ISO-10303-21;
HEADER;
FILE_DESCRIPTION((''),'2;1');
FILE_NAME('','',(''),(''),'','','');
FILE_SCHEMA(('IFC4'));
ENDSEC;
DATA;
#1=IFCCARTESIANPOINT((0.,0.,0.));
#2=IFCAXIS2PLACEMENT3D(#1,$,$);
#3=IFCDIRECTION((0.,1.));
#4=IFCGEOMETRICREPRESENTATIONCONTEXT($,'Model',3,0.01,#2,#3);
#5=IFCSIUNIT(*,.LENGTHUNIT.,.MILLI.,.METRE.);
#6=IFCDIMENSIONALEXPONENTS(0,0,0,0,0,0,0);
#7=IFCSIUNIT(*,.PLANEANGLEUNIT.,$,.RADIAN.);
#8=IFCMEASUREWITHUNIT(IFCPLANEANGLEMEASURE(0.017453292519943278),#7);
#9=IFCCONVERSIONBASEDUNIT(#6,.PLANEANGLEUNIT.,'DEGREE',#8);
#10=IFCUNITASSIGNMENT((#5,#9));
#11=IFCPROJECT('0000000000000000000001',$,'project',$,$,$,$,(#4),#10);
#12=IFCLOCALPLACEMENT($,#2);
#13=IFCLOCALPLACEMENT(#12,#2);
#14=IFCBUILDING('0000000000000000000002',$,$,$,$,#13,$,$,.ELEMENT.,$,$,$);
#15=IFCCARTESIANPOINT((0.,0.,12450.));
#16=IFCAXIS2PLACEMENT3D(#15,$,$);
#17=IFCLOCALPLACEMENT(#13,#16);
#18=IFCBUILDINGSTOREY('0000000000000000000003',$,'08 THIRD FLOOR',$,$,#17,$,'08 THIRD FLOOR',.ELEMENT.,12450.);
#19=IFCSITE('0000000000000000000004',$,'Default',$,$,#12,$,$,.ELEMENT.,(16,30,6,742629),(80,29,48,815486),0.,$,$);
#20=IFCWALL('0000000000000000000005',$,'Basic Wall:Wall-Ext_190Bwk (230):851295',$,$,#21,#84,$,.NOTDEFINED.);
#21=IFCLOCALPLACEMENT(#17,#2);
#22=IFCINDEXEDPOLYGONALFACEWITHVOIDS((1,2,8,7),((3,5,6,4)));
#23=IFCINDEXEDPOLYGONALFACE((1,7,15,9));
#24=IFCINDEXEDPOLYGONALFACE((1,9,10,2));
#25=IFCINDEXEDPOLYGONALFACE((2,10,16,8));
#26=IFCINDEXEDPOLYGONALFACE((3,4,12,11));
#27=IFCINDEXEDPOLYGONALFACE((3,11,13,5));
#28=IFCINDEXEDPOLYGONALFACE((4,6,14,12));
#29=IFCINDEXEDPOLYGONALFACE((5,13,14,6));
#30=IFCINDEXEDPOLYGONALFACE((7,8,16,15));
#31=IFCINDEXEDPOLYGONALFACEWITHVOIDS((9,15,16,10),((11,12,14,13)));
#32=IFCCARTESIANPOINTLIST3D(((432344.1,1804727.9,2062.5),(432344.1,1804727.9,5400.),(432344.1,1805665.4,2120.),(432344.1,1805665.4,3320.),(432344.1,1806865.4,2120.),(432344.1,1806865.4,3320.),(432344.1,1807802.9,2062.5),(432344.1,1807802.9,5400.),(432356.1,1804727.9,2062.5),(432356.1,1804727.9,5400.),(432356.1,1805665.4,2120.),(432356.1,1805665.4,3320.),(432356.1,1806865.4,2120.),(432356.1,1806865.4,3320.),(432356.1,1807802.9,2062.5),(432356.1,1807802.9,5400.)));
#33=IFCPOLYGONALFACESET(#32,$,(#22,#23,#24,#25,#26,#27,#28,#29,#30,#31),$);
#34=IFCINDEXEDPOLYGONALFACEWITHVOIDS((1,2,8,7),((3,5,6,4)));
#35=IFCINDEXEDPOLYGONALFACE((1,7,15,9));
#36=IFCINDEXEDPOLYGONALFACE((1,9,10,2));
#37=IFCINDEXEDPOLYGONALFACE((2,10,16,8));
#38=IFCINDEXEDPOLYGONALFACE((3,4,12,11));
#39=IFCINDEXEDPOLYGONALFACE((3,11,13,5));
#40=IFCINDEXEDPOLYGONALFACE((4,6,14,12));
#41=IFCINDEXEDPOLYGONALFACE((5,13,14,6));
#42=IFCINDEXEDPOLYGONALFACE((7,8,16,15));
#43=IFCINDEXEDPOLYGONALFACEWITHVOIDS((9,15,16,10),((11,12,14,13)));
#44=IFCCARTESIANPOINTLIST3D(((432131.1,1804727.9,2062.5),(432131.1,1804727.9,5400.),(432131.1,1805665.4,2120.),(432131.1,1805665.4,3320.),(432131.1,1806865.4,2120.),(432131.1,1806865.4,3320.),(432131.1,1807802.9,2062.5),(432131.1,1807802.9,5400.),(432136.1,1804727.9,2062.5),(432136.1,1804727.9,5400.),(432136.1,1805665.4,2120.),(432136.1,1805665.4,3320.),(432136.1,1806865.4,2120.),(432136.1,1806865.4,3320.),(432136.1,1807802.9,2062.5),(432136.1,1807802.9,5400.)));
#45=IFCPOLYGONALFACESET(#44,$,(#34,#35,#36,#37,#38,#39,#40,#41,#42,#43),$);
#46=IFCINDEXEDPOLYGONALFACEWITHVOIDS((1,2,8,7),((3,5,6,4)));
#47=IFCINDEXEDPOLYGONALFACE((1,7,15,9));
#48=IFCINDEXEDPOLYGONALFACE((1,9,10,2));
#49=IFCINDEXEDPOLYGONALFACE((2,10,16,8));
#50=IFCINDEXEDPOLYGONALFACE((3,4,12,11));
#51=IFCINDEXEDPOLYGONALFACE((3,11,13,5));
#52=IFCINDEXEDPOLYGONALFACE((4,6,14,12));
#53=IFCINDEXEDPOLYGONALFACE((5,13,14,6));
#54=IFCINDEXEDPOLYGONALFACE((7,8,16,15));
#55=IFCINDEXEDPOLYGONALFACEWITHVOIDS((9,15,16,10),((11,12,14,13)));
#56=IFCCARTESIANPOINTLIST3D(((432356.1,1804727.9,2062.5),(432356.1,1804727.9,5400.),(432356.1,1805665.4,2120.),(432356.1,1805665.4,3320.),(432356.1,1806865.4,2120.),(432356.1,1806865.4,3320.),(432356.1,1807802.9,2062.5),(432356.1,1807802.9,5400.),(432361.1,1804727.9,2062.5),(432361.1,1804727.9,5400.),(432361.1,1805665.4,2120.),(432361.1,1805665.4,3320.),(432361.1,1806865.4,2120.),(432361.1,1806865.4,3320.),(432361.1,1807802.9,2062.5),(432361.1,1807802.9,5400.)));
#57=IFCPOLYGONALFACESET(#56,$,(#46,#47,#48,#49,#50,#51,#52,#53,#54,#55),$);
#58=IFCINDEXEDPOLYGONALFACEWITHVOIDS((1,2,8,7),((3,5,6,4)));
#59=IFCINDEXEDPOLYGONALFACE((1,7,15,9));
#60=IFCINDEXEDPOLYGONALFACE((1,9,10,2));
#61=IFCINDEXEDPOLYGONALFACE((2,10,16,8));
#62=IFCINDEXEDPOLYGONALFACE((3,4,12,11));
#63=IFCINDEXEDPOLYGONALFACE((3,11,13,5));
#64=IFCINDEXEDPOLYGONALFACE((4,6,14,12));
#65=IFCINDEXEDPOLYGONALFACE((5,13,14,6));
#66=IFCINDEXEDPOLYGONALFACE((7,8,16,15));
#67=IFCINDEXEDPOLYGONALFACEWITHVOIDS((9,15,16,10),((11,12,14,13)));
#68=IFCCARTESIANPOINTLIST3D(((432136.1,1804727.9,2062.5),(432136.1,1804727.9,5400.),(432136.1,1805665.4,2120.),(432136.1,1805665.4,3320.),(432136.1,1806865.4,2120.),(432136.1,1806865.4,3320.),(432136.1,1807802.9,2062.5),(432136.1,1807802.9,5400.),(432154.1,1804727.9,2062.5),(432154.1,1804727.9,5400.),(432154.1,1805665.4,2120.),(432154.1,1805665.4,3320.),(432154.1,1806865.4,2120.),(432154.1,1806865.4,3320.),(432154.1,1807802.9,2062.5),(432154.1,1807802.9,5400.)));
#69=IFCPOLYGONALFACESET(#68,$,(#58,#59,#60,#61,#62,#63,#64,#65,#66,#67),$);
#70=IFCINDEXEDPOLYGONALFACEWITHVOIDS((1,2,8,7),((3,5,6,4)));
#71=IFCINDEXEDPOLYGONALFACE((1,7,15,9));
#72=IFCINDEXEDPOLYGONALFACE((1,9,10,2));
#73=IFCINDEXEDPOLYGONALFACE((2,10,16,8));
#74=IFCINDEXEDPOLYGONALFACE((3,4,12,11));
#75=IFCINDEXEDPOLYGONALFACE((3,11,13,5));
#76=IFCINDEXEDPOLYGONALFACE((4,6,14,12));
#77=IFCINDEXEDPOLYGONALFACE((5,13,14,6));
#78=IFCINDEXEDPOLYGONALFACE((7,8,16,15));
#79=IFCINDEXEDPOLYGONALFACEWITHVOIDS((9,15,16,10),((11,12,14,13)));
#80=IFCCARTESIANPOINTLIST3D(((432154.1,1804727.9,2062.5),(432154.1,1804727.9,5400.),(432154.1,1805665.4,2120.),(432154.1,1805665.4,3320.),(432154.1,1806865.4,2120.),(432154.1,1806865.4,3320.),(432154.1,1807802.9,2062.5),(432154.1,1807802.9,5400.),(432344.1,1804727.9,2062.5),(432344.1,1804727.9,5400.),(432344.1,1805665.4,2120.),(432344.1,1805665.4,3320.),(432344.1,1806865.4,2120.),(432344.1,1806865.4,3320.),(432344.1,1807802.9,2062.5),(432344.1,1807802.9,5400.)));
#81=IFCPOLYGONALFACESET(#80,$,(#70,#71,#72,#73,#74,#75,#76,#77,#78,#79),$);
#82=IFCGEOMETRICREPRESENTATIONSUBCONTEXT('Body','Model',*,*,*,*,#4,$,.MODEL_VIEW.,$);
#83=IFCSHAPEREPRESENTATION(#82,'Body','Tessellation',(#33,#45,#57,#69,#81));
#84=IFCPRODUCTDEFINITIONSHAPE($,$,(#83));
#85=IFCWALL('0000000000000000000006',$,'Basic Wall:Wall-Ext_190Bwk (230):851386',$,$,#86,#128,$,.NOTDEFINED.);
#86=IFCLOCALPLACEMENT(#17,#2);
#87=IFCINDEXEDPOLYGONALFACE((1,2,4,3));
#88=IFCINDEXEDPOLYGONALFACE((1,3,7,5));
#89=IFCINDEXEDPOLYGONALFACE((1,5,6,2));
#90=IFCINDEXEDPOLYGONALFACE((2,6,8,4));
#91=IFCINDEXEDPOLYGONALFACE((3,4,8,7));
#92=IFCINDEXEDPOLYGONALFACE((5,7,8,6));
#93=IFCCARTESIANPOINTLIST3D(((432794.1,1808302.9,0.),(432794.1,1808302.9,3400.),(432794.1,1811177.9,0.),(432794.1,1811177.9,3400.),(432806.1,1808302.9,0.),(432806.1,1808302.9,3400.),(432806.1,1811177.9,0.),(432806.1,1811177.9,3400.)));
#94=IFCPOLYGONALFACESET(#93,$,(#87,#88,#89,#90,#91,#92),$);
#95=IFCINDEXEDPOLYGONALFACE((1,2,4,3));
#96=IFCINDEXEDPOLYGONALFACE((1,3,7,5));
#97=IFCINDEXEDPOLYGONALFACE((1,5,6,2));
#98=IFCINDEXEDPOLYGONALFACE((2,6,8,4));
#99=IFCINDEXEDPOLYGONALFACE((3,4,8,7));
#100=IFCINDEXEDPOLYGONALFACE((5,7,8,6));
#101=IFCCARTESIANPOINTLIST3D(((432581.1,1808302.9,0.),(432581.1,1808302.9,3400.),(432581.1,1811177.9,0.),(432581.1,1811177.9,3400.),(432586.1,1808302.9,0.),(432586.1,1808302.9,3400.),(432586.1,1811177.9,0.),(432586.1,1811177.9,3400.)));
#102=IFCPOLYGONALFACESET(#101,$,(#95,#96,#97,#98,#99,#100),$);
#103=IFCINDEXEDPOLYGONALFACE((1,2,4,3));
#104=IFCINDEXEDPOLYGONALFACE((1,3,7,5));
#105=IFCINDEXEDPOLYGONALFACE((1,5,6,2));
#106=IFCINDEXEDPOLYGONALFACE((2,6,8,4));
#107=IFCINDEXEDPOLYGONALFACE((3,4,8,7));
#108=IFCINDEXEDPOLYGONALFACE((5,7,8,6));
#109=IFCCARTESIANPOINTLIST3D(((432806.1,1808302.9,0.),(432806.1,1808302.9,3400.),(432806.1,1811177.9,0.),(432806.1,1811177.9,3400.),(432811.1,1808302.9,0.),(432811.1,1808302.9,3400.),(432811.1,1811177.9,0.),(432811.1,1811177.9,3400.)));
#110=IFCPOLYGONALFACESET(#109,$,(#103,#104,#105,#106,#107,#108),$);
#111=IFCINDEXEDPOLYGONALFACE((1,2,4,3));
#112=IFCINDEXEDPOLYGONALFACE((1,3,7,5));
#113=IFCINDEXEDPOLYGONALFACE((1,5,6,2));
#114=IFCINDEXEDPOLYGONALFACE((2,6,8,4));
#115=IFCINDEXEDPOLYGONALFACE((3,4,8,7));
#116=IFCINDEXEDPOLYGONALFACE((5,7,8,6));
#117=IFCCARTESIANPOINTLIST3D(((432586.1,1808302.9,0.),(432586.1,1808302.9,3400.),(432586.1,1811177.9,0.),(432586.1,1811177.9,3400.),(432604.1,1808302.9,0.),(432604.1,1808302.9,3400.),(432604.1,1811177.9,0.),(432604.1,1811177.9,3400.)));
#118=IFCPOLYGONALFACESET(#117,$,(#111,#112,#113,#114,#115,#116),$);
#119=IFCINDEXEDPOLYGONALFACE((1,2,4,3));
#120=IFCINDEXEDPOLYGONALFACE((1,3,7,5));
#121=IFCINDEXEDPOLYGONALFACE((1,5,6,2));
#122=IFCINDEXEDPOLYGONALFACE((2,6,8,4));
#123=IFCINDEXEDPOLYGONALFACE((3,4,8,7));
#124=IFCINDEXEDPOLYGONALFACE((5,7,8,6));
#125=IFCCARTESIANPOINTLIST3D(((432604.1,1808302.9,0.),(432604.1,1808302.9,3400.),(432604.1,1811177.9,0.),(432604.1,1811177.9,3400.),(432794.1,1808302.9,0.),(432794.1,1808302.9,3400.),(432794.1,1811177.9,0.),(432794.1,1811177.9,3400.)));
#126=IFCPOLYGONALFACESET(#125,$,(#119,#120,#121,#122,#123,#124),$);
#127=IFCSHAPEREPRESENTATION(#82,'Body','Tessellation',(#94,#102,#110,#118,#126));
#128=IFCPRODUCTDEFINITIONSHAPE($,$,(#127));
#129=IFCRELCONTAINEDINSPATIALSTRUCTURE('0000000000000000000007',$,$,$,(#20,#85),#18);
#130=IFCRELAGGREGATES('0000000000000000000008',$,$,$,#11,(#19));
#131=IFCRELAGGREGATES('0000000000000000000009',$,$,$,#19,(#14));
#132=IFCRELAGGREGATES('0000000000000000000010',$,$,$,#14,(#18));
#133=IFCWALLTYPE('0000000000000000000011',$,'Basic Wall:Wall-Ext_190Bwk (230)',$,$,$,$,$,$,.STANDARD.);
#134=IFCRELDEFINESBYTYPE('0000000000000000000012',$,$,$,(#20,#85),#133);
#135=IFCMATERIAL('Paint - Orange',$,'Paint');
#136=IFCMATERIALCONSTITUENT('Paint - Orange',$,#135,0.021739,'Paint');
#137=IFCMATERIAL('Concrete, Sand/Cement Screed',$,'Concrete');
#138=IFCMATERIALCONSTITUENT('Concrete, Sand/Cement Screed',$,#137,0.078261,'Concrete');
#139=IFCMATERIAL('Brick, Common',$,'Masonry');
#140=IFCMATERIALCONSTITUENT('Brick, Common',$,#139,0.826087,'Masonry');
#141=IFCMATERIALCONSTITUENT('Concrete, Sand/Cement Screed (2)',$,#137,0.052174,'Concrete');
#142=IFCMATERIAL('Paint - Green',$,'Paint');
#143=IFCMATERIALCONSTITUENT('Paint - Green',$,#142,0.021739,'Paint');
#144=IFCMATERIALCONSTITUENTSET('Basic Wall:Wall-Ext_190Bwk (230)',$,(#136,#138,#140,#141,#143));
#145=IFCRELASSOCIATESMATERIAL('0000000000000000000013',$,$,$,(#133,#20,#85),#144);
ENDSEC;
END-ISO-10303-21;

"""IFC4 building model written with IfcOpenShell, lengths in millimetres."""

from ifc_helpers import new_model, entity, si_unit, converted_unit, direction, frame, origin, place, context, subcontext, project, spatial, indexed_curve, outline, extrude, material, constituent, constituent_set, type_object, element, save


model = new_model("IFC4")

# Units and contexts
model_context = context("Model", 3, precision=0.01, world=origin(), true_north=direction((0.0, 1.0)))
body_context = subcontext(model_context, "Body", "Model", "MODEL_VIEW")
ifc_project = project(units=[si_unit("LENGTHUNIT", "METRE", prefix="MILLI"), converted_unit("PLANEANGLEUNIT", "DEGREE", entity("IfcPlaneAngleMeasure", 0.017453292519943278), si_unit("PLANEANGLEUNIT", "RADIAN"), dimensions=[0, 0, 0, 0, 0, 0, 0])], contexts=[model_context])

# Site, building, storey
site_placement = place(None, origin())
site = spatial("IfcSite", under=ifc_project, at=site_placement, Name="Default", CompositionType="ELEMENT", RefLatitude=(16, 30, 6, 742629), RefLongitude=(80, 29, 48, 815486), RefElevation=0.0)
building_placement = place(site_placement, origin())
building = spatial("IfcBuilding", under=site, at=building_placement, CompositionType="ELEMENT")
storey_placement = place(building_placement, frame((0.0, 0.0, 12450.0)))
storey = spatial("IfcBuildingStorey", under=building, at=storey_placement, Name="08 THIRD FLOOR", LongName="08 THIRD FLOOR", CompositionType="ELEMENT", Elevation=12450.0)

# Shared definitions
ifc_material_1 = material(Name="Concrete, Sand/Cement Screed", Category="Concrete")
ifc_material_2 = material(Name="Brick, Common", Category="Masonry")

# Wall, opening
ifc_material_3 = material(Name="Paint - Orange", Category="Paint")
ifc_constituent_1 = constituent(ifc_material_3, Name="Paint - Orange", Category="Paint", fraction=0.021739)
ifc_constituent_2 = constituent(ifc_material_1, Name="Concrete, Sand/Cement Screed", Category="Concrete", fraction=0.078261)
ifc_constituent_3 = constituent(ifc_material_2, Name="Brick, Common", Category="Masonry", fraction=0.826087)
ifc_constituent_4 = constituent(ifc_material_1, Name="Concrete, Sand/Cement Screed (2)", Category="Concrete", fraction=0.052174)
ifc_material_4 = material(Name="Paint - Green", Category="Paint")
ifc_constituent_5 = constituent(ifc_material_4, Name="Paint - Green", Category="Paint", fraction=0.021739)
ifc_constituent_set_1 = constituent_set(constituents=[ifc_constituent_1, ifc_constituent_2, ifc_constituent_3, ifc_constituent_4, ifc_constituent_5], Name="Basic Wall:Wall-Ext_190Bwk (230)")
wall_type_1 = type_object("IfcWallType", Name="Basic Wall:Wall-Ext_190Bwk (230)", PredefinedType="STANDARD", material=ifc_constituent_set_1)
wall_1_placement = place(storey_placement, frame((432246.1, 1807802.9, 2062.5), z_axis=(0.0, 0.0, 1.0), x_axis=(0.0, -1.0, 0.0)))
wall_1 = element("IfcWall", 1, at=wall_1_placement, inside=storey, type_object=wall_type_1, material=ifc_constituent_set_1, Name="Basic Wall:Wall-Ext_190Bwk (230):851295", PredefinedType="NOTDEFINED", context=body_context, shape_type="SweptSolid", body=[
    extrude(outline(indexed_curve([(-1668.8, -1537.5), (1668.8, -1537.5), (1668.8, 1537.5), (-1668.8, 1537.5), (-1668.8, -1537.5)], self_intersect=False), holes=[indexed_curve([(-411.2, 600.0), (-411.2, -600.0), (-1611.2, -600.0), (-1611.2, 600.0), (-411.2, 600.0)], self_intersect=False)]), frame((1537.5, 98.0, 1668.8), z_axis=(0.0, 1.0, 0.0), x_axis=(0.0, 0.0, 1.0)), (0.0, 0.0, 1.0), 12.0),
    extrude(outline(indexed_curve([(-1668.8, -1537.5), (1668.8, -1537.5), (1668.8, 1537.5), (-1668.8, 1537.5), (-1668.8, -1537.5)], self_intersect=False), holes=[indexed_curve([(-411.2, 600.0), (-411.2, -600.0), (-1611.2, -600.0), (-1611.2, 600.0), (-411.2, 600.0)], self_intersect=False)]), frame((1537.5, -115.0, 1668.8), z_axis=(0.0, 1.0, 0.0), x_axis=(0.0, 0.0, 1.0)), (0.0, 0.0, 1.0), 5.0),
    extrude(outline(indexed_curve([(-1668.8, -1537.5), (1668.8, -1537.5), (1668.8, 1537.5), (-1668.8, 1537.5), (-1668.8, -1537.5)], self_intersect=False), holes=[indexed_curve([(-411.2, 600.0), (-411.2, -600.0), (-1611.2, -600.0), (-1611.2, 600.0), (-411.2, 600.0)], self_intersect=False)]), frame((1537.5, 110.0, 1668.8), z_axis=(0.0, 1.0, 0.0), x_axis=(0.0, 0.0, 1.0)), (0.0, 0.0, 1.0), 5.0),
    extrude(outline(indexed_curve([(-1668.8, -1537.5), (1668.8, -1537.5), (1668.8, 1537.5), (-1668.8, 1537.5), (-1668.8, -1537.5)], self_intersect=False), holes=[indexed_curve([(-411.2, 600.0), (-411.2, -600.0), (-1611.2, -600.0), (-1611.2, 600.0), (-411.2, 600.0)], self_intersect=False)]), frame((1537.5, -110.0, 1668.8), z_axis=(0.0, 1.0, 0.0), x_axis=(0.0, 0.0, 1.0)), (0.0, 0.0, 1.0), 18.0),
    extrude(outline(indexed_curve([(-1668.8, -1537.5), (1668.8, -1537.5), (1668.8, 1537.5), (-1668.8, 1537.5), (-1668.8, -1537.5)], self_intersect=False), holes=[indexed_curve([(-411.2, 600.0), (-411.2, -600.0), (-1611.2, -600.0), (-1611.2, 600.0), (-411.2, 600.0)], self_intersect=False)]), frame((1537.5, -92.0, 1668.8), z_axis=(0.0, 1.0, 0.0), x_axis=(0.0, 0.0, 1.0)), (0.0, 0.0, 1.0), 190.0),
])
opening_1_placement = place(wall_1_placement, frame((2137.5, 115.0, 57.5)))
element("IfcOpeningElement", 2, at=opening_1_placement, cuts=wall_1, PredefinedType="OPENING", context=body_context, shape_type="SweptSolid", body=[
    extrude(outline(indexed_curve([(1200.0, 0.0), (1200.0, 1200.0), (0.0, 1200.0), (0.0, 0.0), (1200.0, 0.0)], self_intersect=False)), frame((0.0, 0.0, 0.0), z_axis=(0.0, -1.0, 0.0), x_axis=(0.0, 0.0, 1.0)), (0.0, 0.0, 1.0), 230.0),
])

# Wall
wall_2_placement = place(storey_placement, frame((432696.1, 1808302.9, 0.0), z_axis=(0.0, 0.0, 1.0), x_axis=(0.0, 1.0, 0.0)))
element("IfcWall", 3, at=wall_2_placement, inside=storey, type_object=wall_type_1, material=ifc_constituent_set_1, Name="Basic Wall:Wall-Ext_190Bwk (230):851386", PredefinedType="NOTDEFINED", context=body_context, shape_type="SweptSolid", body=[
    extrude(outline(indexed_curve([(-1437.5, -6.0), (1437.5, -6.0), (1437.5, 6.0), (-1437.5, 6.0), (-1437.5, -6.0)], self_intersect=False)), frame((1437.5, -104.0, 0.0)), (0.0, 0.0, 1.0), 3400.0),
    extrude(outline(indexed_curve([(-2.5, -1437.5), (2.5, -1437.5), (2.5, 1437.5), (-2.5, 1437.5), (-2.5, -1437.5)], self_intersect=False)), frame((1437.5, 112.5, 0.0), z_axis=(0.0, 0.0, 1.0), x_axis=(0.0, -1.0, 0.0)), (0.0, 0.0, 1.0), 3400.0),
    extrude(outline(indexed_curve([(-2.5, -1437.5), (2.5, -1437.5), (2.5, 1437.5), (-2.5, 1437.5), (-2.5, -1437.5)], self_intersect=False)), frame((1437.5, -112.5, 0.0), z_axis=(0.0, 0.0, 1.0), x_axis=(0.0, 1.0, 0.0)), (0.0, 0.0, 1.0), 3400.0),
    extrude(outline(indexed_curve([(-1437.5, -9.0), (1437.5, -9.0), (1437.5, 9.0), (-1437.5, 9.0), (-1437.5, -9.0)], self_intersect=False)), frame((1437.5, 101.0, 0.0)), (0.0, 0.0, 1.0), 3400.0),
    extrude(outline(indexed_curve([(-1437.5, -95.0), (1437.5, -95.0), (1437.5, 95.0), (-1437.5, 95.0), (-1437.5, -95.0)], self_intersect=False)), frame((1437.5, -3.0, 0.0)), (0.0, 0.0, 1.0), 3400.0),
])

save(model, "model.ifc")
